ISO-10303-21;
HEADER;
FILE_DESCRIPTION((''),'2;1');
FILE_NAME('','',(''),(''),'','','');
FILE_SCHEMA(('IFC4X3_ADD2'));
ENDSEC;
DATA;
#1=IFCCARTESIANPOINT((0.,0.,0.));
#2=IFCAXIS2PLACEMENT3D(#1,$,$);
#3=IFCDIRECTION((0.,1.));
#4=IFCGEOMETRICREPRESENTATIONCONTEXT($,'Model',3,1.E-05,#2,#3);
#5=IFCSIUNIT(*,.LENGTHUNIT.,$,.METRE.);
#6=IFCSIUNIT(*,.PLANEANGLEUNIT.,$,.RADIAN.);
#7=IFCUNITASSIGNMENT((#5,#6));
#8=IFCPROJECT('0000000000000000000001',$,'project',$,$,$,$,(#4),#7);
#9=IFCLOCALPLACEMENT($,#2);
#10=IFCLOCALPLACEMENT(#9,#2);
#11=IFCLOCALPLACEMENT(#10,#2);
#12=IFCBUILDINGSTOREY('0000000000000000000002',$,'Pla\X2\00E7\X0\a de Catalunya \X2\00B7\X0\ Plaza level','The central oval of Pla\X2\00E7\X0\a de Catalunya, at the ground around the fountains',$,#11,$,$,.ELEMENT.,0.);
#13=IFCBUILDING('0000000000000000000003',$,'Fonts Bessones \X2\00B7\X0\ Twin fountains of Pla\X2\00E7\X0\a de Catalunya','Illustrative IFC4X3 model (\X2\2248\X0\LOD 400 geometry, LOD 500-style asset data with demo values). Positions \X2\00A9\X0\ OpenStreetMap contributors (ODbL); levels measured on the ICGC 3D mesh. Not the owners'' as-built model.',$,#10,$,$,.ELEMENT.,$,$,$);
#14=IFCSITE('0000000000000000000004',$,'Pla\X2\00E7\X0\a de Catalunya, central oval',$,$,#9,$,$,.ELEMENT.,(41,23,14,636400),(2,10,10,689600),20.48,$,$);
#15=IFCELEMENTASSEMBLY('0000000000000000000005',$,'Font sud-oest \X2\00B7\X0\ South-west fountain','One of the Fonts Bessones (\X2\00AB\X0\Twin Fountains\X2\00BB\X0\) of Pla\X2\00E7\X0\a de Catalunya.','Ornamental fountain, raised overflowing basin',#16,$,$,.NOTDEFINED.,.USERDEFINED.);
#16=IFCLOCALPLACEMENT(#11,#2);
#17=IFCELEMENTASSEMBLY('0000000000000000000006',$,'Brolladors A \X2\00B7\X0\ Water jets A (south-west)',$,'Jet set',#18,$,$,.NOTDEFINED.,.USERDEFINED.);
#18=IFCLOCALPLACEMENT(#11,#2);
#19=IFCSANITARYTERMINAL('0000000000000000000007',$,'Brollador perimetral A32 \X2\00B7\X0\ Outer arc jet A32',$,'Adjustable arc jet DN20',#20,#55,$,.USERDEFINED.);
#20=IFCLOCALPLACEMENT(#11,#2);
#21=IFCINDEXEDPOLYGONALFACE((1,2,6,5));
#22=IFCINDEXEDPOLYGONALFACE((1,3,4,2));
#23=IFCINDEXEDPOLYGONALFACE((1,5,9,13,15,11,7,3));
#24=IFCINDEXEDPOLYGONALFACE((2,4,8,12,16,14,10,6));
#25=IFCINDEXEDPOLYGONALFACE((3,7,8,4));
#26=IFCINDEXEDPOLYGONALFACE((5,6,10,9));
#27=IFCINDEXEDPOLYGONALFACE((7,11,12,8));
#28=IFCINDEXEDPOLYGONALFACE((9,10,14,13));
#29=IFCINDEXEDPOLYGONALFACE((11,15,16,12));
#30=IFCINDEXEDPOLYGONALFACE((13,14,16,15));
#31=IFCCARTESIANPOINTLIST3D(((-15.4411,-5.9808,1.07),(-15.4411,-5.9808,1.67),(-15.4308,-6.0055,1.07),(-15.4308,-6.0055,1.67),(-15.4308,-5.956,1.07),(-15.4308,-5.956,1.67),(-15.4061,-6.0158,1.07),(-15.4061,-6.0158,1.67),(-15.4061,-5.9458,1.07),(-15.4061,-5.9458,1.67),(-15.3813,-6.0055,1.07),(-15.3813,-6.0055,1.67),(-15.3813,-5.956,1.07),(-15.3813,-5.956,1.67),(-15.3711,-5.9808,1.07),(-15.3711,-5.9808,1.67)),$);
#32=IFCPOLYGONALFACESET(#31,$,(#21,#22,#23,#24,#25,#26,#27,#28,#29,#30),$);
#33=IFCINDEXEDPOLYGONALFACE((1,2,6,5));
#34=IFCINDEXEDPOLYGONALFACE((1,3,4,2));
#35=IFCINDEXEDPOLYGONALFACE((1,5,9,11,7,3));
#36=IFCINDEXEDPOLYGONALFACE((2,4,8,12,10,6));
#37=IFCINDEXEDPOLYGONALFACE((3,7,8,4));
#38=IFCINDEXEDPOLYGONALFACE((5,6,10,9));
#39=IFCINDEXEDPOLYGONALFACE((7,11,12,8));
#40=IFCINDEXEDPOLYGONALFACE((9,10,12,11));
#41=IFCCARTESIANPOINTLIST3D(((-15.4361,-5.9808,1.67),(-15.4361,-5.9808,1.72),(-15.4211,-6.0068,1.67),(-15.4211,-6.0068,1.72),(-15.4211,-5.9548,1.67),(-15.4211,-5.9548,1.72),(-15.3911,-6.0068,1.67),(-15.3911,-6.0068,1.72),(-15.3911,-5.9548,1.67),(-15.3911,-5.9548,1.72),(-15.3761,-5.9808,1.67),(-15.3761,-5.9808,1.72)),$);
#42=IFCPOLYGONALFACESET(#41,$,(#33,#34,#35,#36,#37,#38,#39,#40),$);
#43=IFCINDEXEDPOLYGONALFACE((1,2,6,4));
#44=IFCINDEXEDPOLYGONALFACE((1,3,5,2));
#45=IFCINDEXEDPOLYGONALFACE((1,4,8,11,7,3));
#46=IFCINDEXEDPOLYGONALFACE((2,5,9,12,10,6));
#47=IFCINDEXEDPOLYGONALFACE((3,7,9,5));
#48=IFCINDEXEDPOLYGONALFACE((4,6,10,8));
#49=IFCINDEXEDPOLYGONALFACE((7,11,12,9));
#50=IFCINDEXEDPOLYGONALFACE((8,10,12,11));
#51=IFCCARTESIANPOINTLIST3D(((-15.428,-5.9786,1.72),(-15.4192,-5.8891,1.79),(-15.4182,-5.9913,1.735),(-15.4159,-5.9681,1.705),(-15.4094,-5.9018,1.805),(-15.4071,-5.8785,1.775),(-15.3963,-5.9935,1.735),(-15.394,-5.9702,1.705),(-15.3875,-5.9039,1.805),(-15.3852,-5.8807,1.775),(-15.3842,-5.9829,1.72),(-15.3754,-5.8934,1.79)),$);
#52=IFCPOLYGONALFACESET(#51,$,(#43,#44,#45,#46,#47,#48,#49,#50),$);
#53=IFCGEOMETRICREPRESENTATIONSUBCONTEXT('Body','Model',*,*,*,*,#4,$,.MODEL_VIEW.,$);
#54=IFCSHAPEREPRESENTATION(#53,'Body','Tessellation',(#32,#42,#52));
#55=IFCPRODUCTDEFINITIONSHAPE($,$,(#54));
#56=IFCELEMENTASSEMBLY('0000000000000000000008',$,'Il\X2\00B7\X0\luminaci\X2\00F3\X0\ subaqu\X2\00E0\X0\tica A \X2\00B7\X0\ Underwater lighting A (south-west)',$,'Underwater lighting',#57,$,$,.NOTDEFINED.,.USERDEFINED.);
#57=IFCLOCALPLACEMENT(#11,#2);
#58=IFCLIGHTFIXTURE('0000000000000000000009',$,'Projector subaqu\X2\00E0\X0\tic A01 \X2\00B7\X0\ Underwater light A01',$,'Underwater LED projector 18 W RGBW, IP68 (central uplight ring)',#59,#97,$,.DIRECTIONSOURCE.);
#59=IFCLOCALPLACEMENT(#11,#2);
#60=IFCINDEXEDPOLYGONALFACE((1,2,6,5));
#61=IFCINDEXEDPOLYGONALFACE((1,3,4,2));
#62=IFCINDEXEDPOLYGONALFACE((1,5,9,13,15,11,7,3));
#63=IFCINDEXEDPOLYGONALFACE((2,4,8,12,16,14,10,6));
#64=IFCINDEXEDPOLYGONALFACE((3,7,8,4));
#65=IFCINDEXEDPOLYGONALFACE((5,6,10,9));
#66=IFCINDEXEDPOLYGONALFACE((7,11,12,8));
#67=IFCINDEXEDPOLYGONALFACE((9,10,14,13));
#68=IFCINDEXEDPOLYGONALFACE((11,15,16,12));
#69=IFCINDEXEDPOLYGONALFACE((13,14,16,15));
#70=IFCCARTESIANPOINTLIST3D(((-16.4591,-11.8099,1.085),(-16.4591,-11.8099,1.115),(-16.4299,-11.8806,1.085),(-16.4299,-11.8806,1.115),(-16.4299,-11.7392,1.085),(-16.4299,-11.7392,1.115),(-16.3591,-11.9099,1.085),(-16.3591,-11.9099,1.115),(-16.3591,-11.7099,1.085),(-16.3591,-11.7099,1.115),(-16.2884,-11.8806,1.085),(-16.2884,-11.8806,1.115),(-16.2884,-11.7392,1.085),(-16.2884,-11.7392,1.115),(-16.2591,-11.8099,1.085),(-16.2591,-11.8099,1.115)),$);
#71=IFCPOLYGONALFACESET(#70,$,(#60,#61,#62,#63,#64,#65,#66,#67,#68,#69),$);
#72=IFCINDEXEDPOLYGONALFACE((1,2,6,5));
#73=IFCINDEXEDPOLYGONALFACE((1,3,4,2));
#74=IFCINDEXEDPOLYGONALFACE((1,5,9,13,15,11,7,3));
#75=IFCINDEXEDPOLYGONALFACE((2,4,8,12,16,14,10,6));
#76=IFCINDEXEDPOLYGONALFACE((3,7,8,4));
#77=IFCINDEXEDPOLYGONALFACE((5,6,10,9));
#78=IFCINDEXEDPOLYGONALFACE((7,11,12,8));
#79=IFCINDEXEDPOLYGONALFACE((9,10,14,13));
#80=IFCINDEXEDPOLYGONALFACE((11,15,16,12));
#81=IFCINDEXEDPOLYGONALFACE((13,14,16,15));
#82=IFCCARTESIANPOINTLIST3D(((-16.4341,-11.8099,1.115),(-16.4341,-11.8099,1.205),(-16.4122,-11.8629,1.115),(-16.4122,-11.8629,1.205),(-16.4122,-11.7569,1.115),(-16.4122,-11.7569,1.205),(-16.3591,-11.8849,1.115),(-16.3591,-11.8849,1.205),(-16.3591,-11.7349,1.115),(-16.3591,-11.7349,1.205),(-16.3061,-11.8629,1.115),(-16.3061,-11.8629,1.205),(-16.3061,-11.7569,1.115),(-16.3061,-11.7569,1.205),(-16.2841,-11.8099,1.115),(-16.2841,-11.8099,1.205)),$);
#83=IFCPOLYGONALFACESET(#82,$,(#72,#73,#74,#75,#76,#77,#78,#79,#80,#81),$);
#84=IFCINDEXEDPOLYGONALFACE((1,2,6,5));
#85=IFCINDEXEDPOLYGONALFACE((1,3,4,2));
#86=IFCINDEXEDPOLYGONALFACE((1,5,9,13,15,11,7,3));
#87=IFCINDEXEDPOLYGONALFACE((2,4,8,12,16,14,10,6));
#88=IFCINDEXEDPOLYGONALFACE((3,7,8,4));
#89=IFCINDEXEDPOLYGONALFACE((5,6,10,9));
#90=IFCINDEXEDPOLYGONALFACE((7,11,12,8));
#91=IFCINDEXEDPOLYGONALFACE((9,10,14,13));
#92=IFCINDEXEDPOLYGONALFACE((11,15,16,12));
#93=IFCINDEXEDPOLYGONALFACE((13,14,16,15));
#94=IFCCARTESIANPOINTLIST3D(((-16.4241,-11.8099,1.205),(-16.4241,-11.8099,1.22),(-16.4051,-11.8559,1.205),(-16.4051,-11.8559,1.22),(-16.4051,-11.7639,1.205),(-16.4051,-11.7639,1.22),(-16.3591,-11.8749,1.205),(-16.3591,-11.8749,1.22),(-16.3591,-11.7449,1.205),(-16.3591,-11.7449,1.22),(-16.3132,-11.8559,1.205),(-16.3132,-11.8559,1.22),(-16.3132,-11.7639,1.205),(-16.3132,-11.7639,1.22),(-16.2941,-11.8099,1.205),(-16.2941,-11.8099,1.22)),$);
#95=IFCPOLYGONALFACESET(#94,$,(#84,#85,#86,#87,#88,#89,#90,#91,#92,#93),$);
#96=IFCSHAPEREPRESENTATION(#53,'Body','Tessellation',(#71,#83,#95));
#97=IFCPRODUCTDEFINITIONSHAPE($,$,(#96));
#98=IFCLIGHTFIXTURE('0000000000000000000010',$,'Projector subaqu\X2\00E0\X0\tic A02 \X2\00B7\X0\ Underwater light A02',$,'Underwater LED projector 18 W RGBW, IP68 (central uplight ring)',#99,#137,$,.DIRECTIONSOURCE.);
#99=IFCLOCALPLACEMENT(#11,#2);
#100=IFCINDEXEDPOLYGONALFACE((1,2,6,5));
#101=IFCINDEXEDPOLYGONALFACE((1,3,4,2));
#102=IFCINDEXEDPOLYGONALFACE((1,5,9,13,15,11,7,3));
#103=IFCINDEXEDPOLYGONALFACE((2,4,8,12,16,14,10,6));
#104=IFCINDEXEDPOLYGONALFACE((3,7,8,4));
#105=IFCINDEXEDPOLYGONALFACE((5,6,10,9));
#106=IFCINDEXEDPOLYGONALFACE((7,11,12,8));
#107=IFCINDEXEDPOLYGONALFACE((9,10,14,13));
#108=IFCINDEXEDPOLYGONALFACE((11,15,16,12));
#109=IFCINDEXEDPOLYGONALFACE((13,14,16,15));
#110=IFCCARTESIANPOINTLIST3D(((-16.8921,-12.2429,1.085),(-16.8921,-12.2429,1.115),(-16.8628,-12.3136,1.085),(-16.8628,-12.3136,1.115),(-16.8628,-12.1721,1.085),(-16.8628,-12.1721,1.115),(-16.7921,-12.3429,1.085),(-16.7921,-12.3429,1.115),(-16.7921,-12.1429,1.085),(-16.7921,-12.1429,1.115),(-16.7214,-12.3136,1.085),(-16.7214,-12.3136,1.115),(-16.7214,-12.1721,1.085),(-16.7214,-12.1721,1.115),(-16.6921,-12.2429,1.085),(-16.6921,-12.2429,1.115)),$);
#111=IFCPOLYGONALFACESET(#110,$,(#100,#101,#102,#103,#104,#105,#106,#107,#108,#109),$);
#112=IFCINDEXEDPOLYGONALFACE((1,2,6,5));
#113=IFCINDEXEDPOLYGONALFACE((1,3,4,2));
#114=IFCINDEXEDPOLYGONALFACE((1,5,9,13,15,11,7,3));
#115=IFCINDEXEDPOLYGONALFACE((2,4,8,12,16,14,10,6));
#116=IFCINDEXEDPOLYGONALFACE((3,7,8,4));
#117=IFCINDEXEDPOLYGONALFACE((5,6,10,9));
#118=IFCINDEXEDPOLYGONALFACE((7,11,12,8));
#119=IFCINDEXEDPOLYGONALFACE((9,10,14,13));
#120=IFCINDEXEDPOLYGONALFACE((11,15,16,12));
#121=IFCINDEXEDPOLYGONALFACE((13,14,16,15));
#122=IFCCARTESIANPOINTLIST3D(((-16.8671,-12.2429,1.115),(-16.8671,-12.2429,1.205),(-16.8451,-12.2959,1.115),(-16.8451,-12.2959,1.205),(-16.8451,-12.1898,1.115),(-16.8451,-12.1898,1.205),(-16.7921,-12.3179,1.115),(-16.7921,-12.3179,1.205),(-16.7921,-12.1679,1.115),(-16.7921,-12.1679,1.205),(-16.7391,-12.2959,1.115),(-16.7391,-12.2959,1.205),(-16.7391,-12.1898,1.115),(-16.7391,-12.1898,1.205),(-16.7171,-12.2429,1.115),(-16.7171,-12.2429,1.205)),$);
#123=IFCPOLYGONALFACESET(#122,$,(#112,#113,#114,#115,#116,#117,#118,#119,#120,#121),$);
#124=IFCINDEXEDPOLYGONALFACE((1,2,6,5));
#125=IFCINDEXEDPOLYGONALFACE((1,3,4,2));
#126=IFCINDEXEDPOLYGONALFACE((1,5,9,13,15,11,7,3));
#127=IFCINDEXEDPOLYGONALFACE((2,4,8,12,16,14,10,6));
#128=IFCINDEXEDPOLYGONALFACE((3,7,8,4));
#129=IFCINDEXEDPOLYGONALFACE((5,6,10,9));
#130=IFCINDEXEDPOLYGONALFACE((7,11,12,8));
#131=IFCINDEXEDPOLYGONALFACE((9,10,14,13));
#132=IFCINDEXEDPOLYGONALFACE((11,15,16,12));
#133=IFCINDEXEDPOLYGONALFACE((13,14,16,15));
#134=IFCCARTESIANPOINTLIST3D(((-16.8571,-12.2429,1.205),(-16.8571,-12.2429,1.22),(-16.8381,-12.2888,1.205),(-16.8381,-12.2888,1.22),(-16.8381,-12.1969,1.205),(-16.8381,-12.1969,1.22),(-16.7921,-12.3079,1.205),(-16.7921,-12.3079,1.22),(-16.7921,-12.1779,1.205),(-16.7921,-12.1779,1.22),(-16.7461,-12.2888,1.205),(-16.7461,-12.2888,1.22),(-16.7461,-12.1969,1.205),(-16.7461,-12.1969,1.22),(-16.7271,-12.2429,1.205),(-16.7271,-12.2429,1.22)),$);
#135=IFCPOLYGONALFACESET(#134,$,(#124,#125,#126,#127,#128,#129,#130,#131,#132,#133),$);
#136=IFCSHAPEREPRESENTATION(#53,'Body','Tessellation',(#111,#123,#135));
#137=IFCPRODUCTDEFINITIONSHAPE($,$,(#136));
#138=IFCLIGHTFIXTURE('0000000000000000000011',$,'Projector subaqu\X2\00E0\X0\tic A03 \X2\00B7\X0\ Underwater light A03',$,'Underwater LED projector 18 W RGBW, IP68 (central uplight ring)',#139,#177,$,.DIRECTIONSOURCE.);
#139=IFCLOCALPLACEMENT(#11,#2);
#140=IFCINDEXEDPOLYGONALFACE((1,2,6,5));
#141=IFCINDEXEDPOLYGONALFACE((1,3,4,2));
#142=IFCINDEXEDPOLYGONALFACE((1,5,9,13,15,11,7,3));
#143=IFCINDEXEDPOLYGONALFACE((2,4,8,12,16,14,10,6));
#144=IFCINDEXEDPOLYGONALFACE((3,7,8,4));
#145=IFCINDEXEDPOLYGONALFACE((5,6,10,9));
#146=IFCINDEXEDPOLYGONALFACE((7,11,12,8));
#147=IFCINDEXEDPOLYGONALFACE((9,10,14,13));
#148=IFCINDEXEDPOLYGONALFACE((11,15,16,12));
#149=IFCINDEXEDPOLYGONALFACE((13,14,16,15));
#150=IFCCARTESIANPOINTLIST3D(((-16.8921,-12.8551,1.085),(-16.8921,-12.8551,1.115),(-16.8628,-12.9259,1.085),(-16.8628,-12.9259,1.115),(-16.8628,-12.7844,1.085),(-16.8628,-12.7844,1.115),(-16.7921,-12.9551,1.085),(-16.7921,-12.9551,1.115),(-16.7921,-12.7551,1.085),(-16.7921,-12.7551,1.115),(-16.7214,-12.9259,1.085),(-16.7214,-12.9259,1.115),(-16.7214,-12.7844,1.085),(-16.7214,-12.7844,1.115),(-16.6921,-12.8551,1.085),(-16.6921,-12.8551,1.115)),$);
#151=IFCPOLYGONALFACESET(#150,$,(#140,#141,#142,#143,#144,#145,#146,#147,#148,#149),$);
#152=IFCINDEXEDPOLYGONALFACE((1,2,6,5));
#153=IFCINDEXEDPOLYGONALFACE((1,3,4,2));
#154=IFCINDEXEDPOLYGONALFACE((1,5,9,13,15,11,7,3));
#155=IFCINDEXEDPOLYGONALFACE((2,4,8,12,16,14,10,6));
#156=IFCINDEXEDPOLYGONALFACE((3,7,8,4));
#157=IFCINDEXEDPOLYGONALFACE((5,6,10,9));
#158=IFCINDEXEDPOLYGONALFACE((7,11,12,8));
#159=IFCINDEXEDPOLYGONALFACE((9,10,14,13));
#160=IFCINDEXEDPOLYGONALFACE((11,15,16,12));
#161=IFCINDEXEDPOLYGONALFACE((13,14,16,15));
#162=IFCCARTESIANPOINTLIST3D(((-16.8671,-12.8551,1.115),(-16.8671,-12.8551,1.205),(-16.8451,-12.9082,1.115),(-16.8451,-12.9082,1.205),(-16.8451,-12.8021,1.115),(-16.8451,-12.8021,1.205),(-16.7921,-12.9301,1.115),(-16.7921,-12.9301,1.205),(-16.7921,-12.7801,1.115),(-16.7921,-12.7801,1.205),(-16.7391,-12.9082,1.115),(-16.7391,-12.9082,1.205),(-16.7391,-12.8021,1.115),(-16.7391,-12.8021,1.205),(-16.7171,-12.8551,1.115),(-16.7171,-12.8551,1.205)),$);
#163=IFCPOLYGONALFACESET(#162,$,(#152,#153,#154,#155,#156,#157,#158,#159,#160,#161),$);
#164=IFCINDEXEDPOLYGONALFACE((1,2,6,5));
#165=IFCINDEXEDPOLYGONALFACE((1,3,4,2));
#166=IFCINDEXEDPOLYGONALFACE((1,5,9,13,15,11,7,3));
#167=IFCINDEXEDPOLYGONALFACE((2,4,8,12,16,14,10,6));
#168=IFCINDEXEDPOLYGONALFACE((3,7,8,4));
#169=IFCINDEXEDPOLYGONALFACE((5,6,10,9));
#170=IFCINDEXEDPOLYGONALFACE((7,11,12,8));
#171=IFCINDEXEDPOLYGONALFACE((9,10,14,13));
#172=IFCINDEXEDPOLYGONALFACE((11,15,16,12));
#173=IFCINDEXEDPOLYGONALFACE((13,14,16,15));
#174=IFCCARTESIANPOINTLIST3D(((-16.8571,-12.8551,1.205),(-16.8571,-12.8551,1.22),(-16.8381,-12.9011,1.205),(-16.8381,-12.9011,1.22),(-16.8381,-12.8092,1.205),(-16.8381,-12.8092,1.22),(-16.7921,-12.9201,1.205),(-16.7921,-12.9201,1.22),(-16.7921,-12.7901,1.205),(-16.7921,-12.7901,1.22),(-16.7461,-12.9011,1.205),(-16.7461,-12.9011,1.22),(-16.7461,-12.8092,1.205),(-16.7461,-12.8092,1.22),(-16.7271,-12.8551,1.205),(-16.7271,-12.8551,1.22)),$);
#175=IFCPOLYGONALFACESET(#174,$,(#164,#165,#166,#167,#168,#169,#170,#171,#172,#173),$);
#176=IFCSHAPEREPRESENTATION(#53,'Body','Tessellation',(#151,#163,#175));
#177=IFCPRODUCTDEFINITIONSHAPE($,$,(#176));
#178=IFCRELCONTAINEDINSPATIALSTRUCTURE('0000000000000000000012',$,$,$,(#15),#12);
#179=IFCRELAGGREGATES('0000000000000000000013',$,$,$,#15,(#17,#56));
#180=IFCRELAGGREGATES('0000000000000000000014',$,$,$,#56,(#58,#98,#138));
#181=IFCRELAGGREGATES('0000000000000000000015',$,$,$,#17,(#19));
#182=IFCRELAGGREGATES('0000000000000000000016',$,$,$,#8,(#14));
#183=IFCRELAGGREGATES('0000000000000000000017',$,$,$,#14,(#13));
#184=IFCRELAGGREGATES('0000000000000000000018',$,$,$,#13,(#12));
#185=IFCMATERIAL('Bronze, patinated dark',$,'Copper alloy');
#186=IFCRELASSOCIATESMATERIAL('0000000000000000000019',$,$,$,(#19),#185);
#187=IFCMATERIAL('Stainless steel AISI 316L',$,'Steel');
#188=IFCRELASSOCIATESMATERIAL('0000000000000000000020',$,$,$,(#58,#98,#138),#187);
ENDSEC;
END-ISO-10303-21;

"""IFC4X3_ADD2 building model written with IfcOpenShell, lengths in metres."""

from ifc_helpers import new_model, si_unit, direction, frame, origin, place, context, subcontext, project, spatial, polyline, outline, extrude, material, element, aggregate, save


model = new_model("IFC4X3_ADD2")

# Units and contexts
model_context = context("Model", 3, precision=1e-05, world=origin(), true_north=direction((0.0, 1.0)))
body_context = subcontext(model_context, "Body", "Model", "MODEL_VIEW")
ifc_project = project(units=[si_unit("LENGTHUNIT", "METRE"), si_unit("PLANEANGLEUNIT", "RADIAN")], contexts=[model_context])

# Site, building, storey
site_placement = place(None, origin())
site = spatial("IfcSite", under=ifc_project, at=site_placement, Name="Plaça de Catalunya, central oval", CompositionType="ELEMENT", RefLatitude=(41, 23, 14, 636400), RefLongitude=(2, 10, 10, 689600), RefElevation=20.48)
building_placement = place(site_placement, origin())
building = spatial("IfcBuilding", under=site, at=building_placement, Name="Fonts Bessones · Twin fountains of Plaça de Catalunya", Description="Illustrative IFC4X3 model (≈LOD 400 geometry, LOD 500-style asset data with demo values). Positions © OpenStreetMap contributors (ODbL); levels measured on the ICGC 3D mesh. Not the owners' as-built model.", CompositionType="ELEMENT")
storey_placement = place(building_placement, origin())
storey = spatial("IfcBuildingStorey", under=building, at=storey_placement, Name="Plaça de Catalunya · Plaza level", Description="The central oval of Plaça de Catalunya, at the ground around the fountains", CompositionType="ELEMENT", Elevation=0.0)

# Element assemblies, sanitary terminal, light fixtures
assembly_1_placement = place(building_placement, origin())
assembly_1 = element("IfcElementAssembly", 1, at=assembly_1_placement, inside=storey, Name="Font sud-oest · South-west fountain", Description="One of the Fonts Bessones («Twin Fountains») of Plaça de Catalunya.", ObjectType="Ornamental fountain, raised overflowing basin", AssemblyPlace="NOTDEFINED", PredefinedType="USERDEFINED")
assembly_2_placement = place(building_placement, origin())
assembly_2 = element("IfcElementAssembly", 2, at=assembly_2_placement, Name="Brolladors A · Water jets A (south-west)", ObjectType="Jet set", AssemblyPlace="NOTDEFINED", PredefinedType="USERDEFINED")
ifc_material_1 = material(Name="Bronze, patinated dark", Category="Copper alloy")
sanitary_terminal_1_placement = place(building_placement, origin())
sanitary_terminal_1 = element("IfcSanitaryTerminal", 3, at=sanitary_terminal_1_placement, material=ifc_material_1, Name="Brollador perimetral A32 · Outer arc jet A32", ObjectType="Adjustable arc jet DN20", PredefinedType="USERDEFINED", context=body_context, shape_type="SweptSolid", body=[
    extrude(outline(polyline([(-15.3711, -5.9808), (-15.3813, -5.956), (-15.4061, -5.9458), (-15.4308, -5.956), (-15.4411, -5.9808), (-15.4308, -6.0055), (-15.4061, -6.0158), (-15.3813, -6.0055), (-15.3711, -5.9808)])), frame((0.0, 0.0, 1.07)), (0.0, 0.0, 1.0), 0.6),
    extrude(outline(polyline([(-15.3761, -5.9808), (-15.3911, -5.9548), (-15.4211, -5.9548), (-15.4361, -5.9808), (-15.4211, -6.0068), (-15.3911, -6.0068), (-15.3761, -5.9808)])), frame((0.0, 0.0, 1.67)), (0.0, 0.0, 1.0), 0.05),
    extrude(outline(polyline([(0.022, 0.0), (0.011, 0.0191), (-0.011, 0.0191), (-0.022, 0.0), (-0.011, -0.0191), (0.011, -0.0191), (0.022, 0.0)])), frame((-15.4061, -5.9808, 1.72), z_axis=(0.07737, 0.785551, 0.613941), x_axis=(0.995185, -0.098017, 0.0)), (0.0, 0.0, 1.0), 0.114),
])
assembly_3_placement = place(building_placement, origin())
assembly_3 = element("IfcElementAssembly", 4, at=assembly_3_placement, Name="Il·luminació subaquàtica A · Underwater lighting A (south-west)", ObjectType="Underwater lighting", AssemblyPlace="NOTDEFINED", PredefinedType="USERDEFINED")
aggregate(assembly_1, [assembly_2, assembly_3])
ifc_material_2 = material(Name="Stainless steel AISI 316L", Category="Steel")
light_fixture_1_placement = place(building_placement, origin())
light_fixture_1 = element("IfcLightFixture", 5, at=light_fixture_1_placement, material=ifc_material_2, Name="Projector subaquàtic A01 · Underwater light A01", ObjectType="Underwater LED projector 18 W RGBW, IP68 (central uplight ring)", PredefinedType="DIRECTIONSOURCE", context=body_context, shape_type="SweptSolid", body=[
    extrude(outline(polyline([(-16.2591, -11.8099), (-16.2884, -11.7392), (-16.3591, -11.7099), (-16.4299, -11.7392), (-16.4591, -11.8099), (-16.4299, -11.8806), (-16.3591, -11.9099), (-16.2884, -11.8806), (-16.2591, -11.8099)])), frame((0.0, 0.0, 1.085)), (0.0, 0.0, 1.0), 0.03),
    extrude(outline(polyline([(-16.2841, -11.8099), (-16.3061, -11.7569), (-16.3591, -11.7349), (-16.4122, -11.7569), (-16.4341, -11.8099), (-16.4122, -11.8629), (-16.3591, -11.8849), (-16.3061, -11.8629), (-16.2841, -11.8099)])), frame((0.0, 0.0, 1.115)), (0.0, 0.0, 1.0), 0.09),
    extrude(outline(polyline([(-16.2941, -11.8099), (-16.3132, -11.7639), (-16.3591, -11.7449), (-16.4051, -11.7639), (-16.4241, -11.8099), (-16.4051, -11.8559), (-16.3591, -11.8749), (-16.3132, -11.8559), (-16.2941, -11.8099)])), frame((0.0, 0.0, 1.205)), (0.0, 0.0, 1.0), 0.015),
])
light_fixture_2_placement = place(building_placement, origin())
light_fixture_2 = element("IfcLightFixture", 6, at=light_fixture_2_placement, material=ifc_material_2, Name="Projector subaquàtic A02 · Underwater light A02", ObjectType="Underwater LED projector 18 W RGBW, IP68 (central uplight ring)", PredefinedType="DIRECTIONSOURCE", context=body_context, shape_type="SweptSolid", body=[
    extrude(outline(polyline([(-16.6921, -12.2429), (-16.7214, -12.1721), (-16.7921, -12.1429), (-16.8628, -12.1721), (-16.8921, -12.2429), (-16.8628, -12.3136), (-16.7921, -12.3429), (-16.7214, -12.3136), (-16.6921, -12.2429)])), frame((0.0, 0.0, 1.085)), (0.0, 0.0, 1.0), 0.03),
    extrude(outline(polyline([(-16.7171, -12.2429), (-16.7391, -12.1898), (-16.7921, -12.1679), (-16.8451, -12.1898), (-16.8671, -12.2429), (-16.8451, -12.2959), (-16.7921, -12.3179), (-16.7391, -12.2959), (-16.7171, -12.2429)])), frame((0.0, 0.0, 1.115)), (0.0, 0.0, 1.0), 0.09),
    extrude(outline(polyline([(-16.7271, -12.2429), (-16.7461, -12.1969), (-16.7921, -12.1779), (-16.8381, -12.1969), (-16.8571, -12.2429), (-16.8381, -12.2888), (-16.7921, -12.3079), (-16.7461, -12.2888), (-16.7271, -12.2429)])), frame((0.0, 0.0, 1.205)), (0.0, 0.0, 1.0), 0.015),
])
light_fixture_3_placement = place(building_placement, origin())
light_fixture_3 = element("IfcLightFixture", 7, at=light_fixture_3_placement, material=ifc_material_2, Name="Projector subaquàtic A03 · Underwater light A03", ObjectType="Underwater LED projector 18 W RGBW, IP68 (central uplight ring)", PredefinedType="DIRECTIONSOURCE", context=body_context, shape_type="SweptSolid", body=[
    extrude(outline(polyline([(-16.6921, -12.8551), (-16.7214, -12.7844), (-16.7921, -12.7551), (-16.8628, -12.7844), (-16.8921, -12.8551), (-16.8628, -12.9259), (-16.7921, -12.9551), (-16.7214, -12.9259), (-16.6921, -12.8551)])), frame((0.0, 0.0, 1.085)), (0.0, 0.0, 1.0), 0.03),
    extrude(outline(polyline([(-16.7171, -12.8551), (-16.7391, -12.8021), (-16.7921, -12.7801), (-16.8451, -12.8021), (-16.8671, -12.8551), (-16.8451, -12.9082), (-16.7921, -12.9301), (-16.7391, -12.9082), (-16.7171, -12.8551)])), frame((0.0, 0.0, 1.115)), (0.0, 0.0, 1.0), 0.09),
    extrude(outline(polyline([(-16.7271, -12.8551), (-16.7461, -12.8092), (-16.7921, -12.7901), (-16.8381, -12.8092), (-16.8571, -12.8551), (-16.8381, -12.9011), (-16.7921, -12.9201), (-16.7461, -12.9011), (-16.7271, -12.8551)])), frame((0.0, 0.0, 1.205)), (0.0, 0.0, 1.0), 0.015),
])
aggregate(assembly_3, [light_fixture_1, light_fixture_2, light_fixture_3])
aggregate(assembly_2, [sanitary_terminal_1])

save(model, "model.ifc")
